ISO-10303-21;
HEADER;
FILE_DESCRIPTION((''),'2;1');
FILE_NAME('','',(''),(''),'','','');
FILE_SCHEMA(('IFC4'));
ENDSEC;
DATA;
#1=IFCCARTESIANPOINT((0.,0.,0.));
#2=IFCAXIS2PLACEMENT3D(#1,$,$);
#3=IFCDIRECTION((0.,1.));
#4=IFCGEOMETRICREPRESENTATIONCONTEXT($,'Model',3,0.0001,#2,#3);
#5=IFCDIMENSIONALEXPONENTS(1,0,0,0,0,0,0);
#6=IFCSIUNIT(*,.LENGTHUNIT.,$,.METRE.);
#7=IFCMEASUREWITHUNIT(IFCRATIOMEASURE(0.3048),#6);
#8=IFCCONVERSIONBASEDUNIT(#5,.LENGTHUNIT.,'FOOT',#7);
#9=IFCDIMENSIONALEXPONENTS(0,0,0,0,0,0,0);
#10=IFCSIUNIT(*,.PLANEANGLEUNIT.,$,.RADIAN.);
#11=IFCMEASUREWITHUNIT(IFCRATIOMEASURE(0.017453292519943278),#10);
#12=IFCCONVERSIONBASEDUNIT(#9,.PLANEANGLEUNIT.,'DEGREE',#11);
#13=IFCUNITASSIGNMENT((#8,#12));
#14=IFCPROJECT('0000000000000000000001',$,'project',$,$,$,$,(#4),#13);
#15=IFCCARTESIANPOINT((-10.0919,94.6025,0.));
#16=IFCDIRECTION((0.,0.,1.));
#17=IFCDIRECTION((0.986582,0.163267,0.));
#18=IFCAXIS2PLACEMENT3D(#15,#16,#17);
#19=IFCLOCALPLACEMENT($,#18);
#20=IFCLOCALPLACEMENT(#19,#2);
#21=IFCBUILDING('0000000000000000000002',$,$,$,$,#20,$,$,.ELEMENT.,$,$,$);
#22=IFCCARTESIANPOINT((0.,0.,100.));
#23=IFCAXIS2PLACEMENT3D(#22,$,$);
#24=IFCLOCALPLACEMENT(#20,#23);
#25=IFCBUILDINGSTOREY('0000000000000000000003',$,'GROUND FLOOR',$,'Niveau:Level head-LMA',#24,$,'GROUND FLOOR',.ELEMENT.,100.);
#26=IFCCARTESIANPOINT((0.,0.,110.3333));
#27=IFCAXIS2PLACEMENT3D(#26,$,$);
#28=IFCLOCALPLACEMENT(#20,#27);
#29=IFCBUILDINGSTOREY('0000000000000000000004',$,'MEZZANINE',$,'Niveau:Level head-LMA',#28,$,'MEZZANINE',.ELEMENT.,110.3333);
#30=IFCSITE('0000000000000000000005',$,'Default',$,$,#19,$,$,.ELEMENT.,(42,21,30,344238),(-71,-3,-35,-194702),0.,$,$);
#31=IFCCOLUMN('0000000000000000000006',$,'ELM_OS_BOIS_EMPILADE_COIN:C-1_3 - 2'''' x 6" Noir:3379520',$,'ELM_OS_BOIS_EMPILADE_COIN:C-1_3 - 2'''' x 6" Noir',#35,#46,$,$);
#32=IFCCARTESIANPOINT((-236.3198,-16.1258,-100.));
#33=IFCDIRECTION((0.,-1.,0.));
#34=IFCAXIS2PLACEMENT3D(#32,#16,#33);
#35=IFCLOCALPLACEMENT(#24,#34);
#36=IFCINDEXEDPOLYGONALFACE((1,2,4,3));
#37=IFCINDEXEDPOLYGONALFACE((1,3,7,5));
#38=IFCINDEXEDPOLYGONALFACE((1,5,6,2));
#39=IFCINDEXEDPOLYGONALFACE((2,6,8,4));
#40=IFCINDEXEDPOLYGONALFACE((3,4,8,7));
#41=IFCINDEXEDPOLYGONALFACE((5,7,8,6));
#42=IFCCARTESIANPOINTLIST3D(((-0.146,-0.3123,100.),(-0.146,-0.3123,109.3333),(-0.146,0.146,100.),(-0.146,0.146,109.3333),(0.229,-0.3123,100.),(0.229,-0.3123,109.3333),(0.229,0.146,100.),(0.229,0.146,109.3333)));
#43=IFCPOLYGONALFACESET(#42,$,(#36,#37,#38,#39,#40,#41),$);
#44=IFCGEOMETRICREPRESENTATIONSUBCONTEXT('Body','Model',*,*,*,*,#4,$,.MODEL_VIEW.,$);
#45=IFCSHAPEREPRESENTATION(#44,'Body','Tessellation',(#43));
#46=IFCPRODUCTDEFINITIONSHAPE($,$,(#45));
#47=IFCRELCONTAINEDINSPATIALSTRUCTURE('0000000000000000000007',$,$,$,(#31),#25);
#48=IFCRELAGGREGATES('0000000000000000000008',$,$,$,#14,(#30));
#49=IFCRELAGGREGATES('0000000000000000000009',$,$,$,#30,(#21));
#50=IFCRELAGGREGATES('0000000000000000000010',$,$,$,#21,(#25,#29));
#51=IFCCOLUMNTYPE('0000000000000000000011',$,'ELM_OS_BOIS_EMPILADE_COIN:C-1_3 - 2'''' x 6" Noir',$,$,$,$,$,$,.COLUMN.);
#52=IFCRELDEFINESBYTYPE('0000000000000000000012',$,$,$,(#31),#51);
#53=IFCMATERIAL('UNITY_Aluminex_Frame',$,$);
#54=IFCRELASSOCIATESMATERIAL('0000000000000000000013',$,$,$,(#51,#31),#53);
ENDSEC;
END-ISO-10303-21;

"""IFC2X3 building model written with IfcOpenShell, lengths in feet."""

from ifc_helpers import new_model, entity, si_unit, converted_unit, direction, frame, origin, origin_2d_with_axis, place, context, subcontext, project, spatial, rectangle, extrude, source, transform, mapped, material, type_object, type_shapes, element, save


model = new_model("IFC2X3")

# Units and contexts
model_context = context("Model", 3, precision=0.0001, world=origin(), true_north=direction((0.0, 1.0)))
body_context = subcontext(model_context, "Body", "Model", "MODEL_VIEW")
ifc_project = project(units=[converted_unit("LENGTHUNIT", "FOOT", entity("IfcRatioMeasure", 0.3048), si_unit("LENGTHUNIT", "METRE"), dimensions=[1, 0, 0, 0, 0, 0, 0]), converted_unit("PLANEANGLEUNIT", "DEGREE", entity("IfcRatioMeasure", 0.017453292519943278), si_unit("PLANEANGLEUNIT", "RADIAN"), dimensions=[0, 0, 0, 0, 0, 0, 0])], contexts=[model_context])

# Site, building, storey
site_placement = place(None, frame((-10.0919, 94.6025, 0.0), z_axis=(0.0, 0.0, 1.0), x_axis=(0.986582, 0.163267, 0.0)))
site = spatial("IfcSite", under=ifc_project, at=site_placement, Name="Default", CompositionType="ELEMENT", RefLatitude=(42, 21, 30, 344238), RefLongitude=(-71, -3, -35, -194702), RefElevation=0.0)
building_placement = place(site_placement, origin())
building = spatial("IfcBuilding", under=site, at=building_placement, CompositionType="ELEMENT")
storey_1_placement = place(building_placement, frame((0.0, 0.0, 100.0)))
storey_1 = spatial("IfcBuildingStorey", under=building, at=storey_1_placement, Name="GROUND FLOOR", ObjectType="Niveau:Level head-LMA", LongName="GROUND FLOOR", CompositionType="ELEMENT", Elevation=100.0)

# Column
ifc_material_1 = material(Name="UNITY_Aluminex_Frame")
column_type = type_object("IfcColumnType", Name="ELM_OS_BOIS_EMPILADE_COIN:C-1_3 - 2'' x 6\" Noir", PredefinedType="COLUMN", material=ifc_material_1)
shared_shape_1 = source(origin(), body_context, "Body", "SweptSolid", [
    extrude(rectangle(XDim=0.4583, YDim=0.375, at=origin_2d_with_axis()), frame((0.0415, -0.0832, 100.0), z_axis=(0.0, 0.0, 1.0), x_axis=(0.0, -1.0, 0.0)), (0.0, 0.0, 1.0), 9.3333),
])
type_shapes(column_type, [shared_shape_1])
column_placement = place(storey_1_placement, frame((-236.3198, -16.1258, -100.0), z_axis=(0.0, 0.0, 1.0), x_axis=(0.0, -1.0, 0.0)))
element("IfcColumn", 1, at=column_placement, inside=storey_1, type_object=column_type, material=ifc_material_1, Name="ELM_OS_BOIS_EMPILADE_COIN:C-1_3 - 2'' x 6\" Noir:3379520", ObjectType="ELM_OS_BOIS_EMPILADE_COIN:C-1_3 - 2'' x 6\" Noir", context=body_context, shape_type="MappedRepresentation", body=[
    mapped(shared_shape_1, transform((0.0, 0.0, 0.0), scale=1.0)),
])

# Shared definitions
storey_2_placement = place(building_placement, frame((0.0, 0.0, 110.3333)))
storey_2 = spatial("IfcBuildingStorey", under=building, at=storey_2_placement, Name="MEZZANINE", ObjectType="Niveau:Level head-LMA", LongName="MEZZANINE", CompositionType="ELEMENT", Elevation=110.3333)

save(model, "model.ifc")
